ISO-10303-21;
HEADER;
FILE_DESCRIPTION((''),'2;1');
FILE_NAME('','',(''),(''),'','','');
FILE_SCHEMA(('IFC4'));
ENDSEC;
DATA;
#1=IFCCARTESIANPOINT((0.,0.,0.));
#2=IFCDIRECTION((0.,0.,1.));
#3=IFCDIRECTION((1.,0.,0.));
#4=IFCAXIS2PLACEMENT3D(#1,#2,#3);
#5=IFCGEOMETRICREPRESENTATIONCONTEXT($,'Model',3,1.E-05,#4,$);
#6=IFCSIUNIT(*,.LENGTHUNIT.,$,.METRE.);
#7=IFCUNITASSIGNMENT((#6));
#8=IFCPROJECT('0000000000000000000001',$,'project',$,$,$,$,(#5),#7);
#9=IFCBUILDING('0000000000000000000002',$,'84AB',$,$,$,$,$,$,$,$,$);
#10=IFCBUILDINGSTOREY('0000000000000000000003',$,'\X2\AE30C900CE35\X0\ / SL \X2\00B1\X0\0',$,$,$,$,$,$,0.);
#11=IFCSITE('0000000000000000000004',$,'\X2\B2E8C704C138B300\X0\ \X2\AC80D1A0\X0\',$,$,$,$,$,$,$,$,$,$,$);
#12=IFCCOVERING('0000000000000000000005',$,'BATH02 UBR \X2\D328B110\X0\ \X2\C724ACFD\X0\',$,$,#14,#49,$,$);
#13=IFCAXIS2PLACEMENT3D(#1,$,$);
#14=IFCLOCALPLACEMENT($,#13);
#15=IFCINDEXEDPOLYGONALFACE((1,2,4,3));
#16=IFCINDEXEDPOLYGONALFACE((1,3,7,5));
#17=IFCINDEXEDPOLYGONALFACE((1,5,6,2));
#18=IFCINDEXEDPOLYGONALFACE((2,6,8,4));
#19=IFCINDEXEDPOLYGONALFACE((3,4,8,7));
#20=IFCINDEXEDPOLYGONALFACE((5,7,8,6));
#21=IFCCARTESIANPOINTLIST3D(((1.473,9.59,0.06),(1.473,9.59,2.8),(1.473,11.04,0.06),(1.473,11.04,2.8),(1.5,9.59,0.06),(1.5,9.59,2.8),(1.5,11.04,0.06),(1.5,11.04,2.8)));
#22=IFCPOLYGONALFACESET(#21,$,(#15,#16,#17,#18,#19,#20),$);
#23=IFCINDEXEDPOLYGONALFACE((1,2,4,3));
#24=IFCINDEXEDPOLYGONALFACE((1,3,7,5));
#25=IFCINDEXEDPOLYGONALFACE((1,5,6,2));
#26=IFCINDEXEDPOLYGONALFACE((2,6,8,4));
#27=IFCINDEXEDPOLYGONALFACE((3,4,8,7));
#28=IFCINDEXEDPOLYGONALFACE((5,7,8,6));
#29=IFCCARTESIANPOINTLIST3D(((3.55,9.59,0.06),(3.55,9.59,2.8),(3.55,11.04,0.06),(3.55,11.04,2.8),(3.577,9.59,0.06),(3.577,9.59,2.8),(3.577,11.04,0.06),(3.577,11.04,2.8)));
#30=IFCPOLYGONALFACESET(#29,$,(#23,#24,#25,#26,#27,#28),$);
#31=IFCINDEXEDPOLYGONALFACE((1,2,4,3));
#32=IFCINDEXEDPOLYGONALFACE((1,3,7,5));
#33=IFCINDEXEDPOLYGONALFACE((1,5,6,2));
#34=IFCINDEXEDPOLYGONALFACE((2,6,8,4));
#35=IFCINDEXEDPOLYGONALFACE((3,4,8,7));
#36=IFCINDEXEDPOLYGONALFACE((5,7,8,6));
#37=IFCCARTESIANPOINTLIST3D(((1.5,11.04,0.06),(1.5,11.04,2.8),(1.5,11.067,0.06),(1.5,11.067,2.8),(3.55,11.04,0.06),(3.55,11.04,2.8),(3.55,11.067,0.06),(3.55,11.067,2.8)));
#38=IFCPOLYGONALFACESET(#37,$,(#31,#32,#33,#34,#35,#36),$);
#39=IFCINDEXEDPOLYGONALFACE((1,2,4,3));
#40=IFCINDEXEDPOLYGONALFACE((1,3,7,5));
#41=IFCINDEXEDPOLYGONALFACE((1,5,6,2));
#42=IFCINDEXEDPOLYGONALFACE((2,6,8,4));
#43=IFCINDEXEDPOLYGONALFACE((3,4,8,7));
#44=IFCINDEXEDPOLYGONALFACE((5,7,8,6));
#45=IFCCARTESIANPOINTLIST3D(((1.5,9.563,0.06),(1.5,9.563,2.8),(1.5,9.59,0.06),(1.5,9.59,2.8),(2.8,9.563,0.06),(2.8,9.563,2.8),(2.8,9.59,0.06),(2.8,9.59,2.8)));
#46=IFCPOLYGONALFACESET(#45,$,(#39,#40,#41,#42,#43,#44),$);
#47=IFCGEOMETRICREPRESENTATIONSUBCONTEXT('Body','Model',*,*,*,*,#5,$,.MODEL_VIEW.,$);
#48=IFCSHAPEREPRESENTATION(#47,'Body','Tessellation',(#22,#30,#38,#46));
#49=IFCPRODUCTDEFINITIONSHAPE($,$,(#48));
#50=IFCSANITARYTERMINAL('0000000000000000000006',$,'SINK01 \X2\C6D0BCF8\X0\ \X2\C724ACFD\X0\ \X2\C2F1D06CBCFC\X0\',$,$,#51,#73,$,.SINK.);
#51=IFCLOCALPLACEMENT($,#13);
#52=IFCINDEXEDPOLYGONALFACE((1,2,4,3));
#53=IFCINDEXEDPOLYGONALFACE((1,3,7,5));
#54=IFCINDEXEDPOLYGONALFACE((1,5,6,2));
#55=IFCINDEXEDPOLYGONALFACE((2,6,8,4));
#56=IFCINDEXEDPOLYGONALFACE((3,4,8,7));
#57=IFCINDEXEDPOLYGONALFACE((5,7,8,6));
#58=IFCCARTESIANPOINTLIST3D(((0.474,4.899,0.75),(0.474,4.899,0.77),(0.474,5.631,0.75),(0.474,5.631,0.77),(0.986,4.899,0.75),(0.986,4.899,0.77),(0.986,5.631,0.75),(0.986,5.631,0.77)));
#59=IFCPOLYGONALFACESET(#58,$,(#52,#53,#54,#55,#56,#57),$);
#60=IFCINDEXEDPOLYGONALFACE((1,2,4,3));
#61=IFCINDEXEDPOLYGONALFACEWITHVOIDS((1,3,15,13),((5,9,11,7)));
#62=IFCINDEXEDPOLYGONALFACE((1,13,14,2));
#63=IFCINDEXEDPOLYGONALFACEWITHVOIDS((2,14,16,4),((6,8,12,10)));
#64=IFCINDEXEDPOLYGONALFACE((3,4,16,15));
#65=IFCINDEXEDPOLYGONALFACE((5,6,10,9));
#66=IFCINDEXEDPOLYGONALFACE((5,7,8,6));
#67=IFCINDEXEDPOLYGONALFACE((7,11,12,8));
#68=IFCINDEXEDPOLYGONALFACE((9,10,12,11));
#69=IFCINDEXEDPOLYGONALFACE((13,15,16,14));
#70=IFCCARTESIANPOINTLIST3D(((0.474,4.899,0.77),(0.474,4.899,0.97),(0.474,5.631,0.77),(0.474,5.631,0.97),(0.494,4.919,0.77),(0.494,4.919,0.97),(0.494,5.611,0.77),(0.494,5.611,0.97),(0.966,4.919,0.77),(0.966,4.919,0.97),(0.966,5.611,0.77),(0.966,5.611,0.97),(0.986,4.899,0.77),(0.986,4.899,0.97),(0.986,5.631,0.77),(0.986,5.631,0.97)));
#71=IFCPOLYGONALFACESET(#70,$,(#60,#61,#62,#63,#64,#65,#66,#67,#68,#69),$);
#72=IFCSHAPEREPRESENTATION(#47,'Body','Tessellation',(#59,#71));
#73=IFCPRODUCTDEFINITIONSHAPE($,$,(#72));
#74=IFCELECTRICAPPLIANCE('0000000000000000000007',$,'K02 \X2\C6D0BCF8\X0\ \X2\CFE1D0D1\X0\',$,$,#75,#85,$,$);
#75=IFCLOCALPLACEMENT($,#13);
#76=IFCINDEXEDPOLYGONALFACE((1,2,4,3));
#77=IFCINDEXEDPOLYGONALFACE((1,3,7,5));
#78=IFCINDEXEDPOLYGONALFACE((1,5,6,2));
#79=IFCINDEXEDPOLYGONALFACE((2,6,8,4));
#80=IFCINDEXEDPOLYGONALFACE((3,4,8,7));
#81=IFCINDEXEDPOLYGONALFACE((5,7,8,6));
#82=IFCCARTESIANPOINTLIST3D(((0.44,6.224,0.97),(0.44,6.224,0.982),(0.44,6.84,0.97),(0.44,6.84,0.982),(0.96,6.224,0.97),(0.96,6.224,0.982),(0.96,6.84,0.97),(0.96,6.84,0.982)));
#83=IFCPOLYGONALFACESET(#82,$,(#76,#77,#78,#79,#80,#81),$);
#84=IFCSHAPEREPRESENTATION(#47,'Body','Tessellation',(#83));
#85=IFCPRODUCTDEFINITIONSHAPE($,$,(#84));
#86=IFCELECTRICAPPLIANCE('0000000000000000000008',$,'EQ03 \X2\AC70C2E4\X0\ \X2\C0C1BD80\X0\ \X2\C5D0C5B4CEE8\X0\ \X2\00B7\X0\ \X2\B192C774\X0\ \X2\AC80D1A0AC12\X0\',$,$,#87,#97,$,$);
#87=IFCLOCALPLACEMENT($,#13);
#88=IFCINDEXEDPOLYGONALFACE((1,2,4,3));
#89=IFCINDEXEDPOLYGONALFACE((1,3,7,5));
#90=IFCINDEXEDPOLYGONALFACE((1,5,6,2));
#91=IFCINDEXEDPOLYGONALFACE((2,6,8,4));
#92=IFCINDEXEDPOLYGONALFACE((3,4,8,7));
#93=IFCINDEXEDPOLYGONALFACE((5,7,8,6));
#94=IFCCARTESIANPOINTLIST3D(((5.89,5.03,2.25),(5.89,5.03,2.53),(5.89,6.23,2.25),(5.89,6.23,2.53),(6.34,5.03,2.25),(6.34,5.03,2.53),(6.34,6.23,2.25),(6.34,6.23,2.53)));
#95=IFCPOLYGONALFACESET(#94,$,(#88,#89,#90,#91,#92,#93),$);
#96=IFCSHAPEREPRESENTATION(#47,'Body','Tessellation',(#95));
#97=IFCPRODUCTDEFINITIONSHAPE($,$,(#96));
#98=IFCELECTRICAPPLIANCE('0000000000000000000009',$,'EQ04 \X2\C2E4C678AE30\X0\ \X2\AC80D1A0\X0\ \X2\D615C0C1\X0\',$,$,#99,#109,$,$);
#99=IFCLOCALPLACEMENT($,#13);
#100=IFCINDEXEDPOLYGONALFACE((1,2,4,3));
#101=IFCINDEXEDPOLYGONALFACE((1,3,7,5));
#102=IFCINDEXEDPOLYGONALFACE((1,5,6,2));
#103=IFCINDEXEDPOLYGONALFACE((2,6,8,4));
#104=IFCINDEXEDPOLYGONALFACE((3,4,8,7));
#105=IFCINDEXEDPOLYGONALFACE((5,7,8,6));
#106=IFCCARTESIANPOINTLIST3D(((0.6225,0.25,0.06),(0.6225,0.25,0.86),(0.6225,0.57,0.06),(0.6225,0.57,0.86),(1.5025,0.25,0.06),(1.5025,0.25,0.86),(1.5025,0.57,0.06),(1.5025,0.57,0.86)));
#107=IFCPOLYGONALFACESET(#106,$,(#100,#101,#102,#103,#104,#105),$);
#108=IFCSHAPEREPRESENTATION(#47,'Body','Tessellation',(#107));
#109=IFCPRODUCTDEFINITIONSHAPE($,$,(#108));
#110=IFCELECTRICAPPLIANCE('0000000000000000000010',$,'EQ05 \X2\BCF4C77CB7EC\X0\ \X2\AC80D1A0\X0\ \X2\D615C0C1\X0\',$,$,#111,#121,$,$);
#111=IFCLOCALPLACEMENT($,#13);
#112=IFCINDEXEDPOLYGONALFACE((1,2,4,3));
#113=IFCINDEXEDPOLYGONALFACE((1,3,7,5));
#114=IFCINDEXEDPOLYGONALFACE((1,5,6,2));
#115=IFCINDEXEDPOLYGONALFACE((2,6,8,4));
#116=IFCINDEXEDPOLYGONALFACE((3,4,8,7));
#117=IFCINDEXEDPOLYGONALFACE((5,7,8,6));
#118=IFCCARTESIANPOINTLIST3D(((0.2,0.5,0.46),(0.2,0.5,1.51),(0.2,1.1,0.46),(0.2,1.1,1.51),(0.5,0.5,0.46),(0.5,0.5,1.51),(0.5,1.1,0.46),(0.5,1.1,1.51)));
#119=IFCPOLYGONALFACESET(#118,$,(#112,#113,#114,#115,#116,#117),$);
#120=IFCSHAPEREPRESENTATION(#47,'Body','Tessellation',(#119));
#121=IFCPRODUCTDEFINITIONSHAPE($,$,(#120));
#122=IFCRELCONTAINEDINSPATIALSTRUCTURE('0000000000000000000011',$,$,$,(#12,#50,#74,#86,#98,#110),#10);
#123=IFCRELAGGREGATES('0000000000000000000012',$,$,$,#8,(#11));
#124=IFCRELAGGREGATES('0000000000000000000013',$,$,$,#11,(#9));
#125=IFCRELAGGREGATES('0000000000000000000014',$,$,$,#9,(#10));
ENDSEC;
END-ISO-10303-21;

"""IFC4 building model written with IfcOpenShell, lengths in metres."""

from ifc_helpers import new_model, si_unit, frame, origin_with_axes, place, context, subcontext, project, spatial, polyline, outline, extrude, element, save


model = new_model("IFC4")

# Units and contexts
model_context = context("Model", 3, precision=1e-05, world=origin_with_axes())
body_context = subcontext(model_context, "Body", "Model", "MODEL_VIEW")
ifc_project = project(units=[si_unit("LENGTHUNIT", "METRE")], contexts=[model_context])

# Site, building, storey
site = spatial("IfcSite", under=ifc_project, Name="단위세대 검토")
building = spatial("IfcBuilding", under=site, Name="84AB")
storey = spatial("IfcBuildingStorey", under=building, Name="기준층 / SL ±0", Elevation=0.0)

# Covering
covering_placement = place(None, origin_with_axes())
element("IfcCovering", 1, at=covering_placement, inside=storey, Name="BATH02 UBR 패널 윤곽", context=body_context, shape_type="SweptSolid", body=[
    extrude(outline(polyline([(1.5, 9.59), (1.5, 11.04), (1.473, 11.04), (1.473, 9.59), (1.5, 9.59)])), frame((0.0, 0.0, 0.06)), (0.0, 0.0, 1.0), 2.74),
    extrude(outline(polyline([(3.577, 9.59), (3.577, 11.04), (3.55, 11.04), (3.55, 9.59), (3.577, 9.59)])), frame((0.0, 0.0, 0.06)), (0.0, 0.0, 1.0), 2.74),
    extrude(outline(polyline([(3.55, 11.04), (3.55, 11.067), (1.5, 11.067), (1.5, 11.04), (3.55, 11.04)])), frame((0.0, 0.0, 0.06)), (0.0, 0.0, 1.0), 2.74),
    extrude(outline(polyline([(2.8, 9.563), (2.8, 9.59), (1.5, 9.59), (1.5, 9.563), (2.8, 9.563)])), frame((0.0, 0.0, 0.06)), (0.0, 0.0, 1.0), 2.74),
])

# Sanitary terminal
sanitary_terminal_1_placement = place(None, origin_with_axes())
element("IfcSanitaryTerminal", 2, at=sanitary_terminal_1_placement, inside=storey, Name="SINK01 원본 윤곽 싱크볼", PredefinedType="SINK", context=body_context, shape_type="SweptSolid", body=[
    extrude(outline(polyline([(0.986, 4.899), (0.986, 5.631), (0.474, 5.631), (0.474, 4.899), (0.986, 4.899)])), frame((0.0, 0.0, 0.75)), (0.0, 0.0, 1.0), 0.02),
    extrude(outline(polyline([(0.474, 4.899), (0.474, 5.631), (0.986, 5.631), (0.986, 4.899), (0.474, 4.899)]), holes=[polyline([(0.966, 5.611), (0.494, 5.611), (0.494, 4.919), (0.966, 4.919), (0.966, 5.611)])]), frame((0.0, 0.0, 0.77)), (0.0, 0.0, 1.0), 0.2),
])

# Electric appliance
electric_appliance_1_placement = place(None, origin_with_axes())
element("IfcElectricAppliance", 3, at=electric_appliance_1_placement, inside=storey, Name="K02 원본 쿡탑", context=body_context, shape_type="SweptSolid", body=[
    extrude(outline(polyline([(0.96, 6.224), (0.96, 6.84), (0.44, 6.84), (0.44, 6.224), (0.96, 6.224)])), frame((0.0, 0.0, 0.97)), (0.0, 0.0, 1.0), 0.012),
])

# Electric appliances
electric_appliance_2_placement = place(None, origin_with_axes())
element("IfcElectricAppliance", 4, at=electric_appliance_2_placement, inside=storey, Name="EQ03 거실 상부 에어컨 · 높이 검토값", context=body_context, shape_type="SweptSolid", body=[
    extrude(outline(polyline([(5.89, 6.23), (5.89, 5.03), (6.34, 5.03), (6.34, 6.23), (5.89, 6.23)])), frame((0.0, 0.0, 2.25)), (0.0, 0.0, 1.0), 0.28),
])
electric_appliance_3_placement = place(None, origin_with_axes())
element("IfcElectricAppliance", 5, at=electric_appliance_3_placement, inside=storey, Name="EQ04 실외기 검토 형상", context=body_context, shape_type="SweptSolid", body=[
    extrude(outline(polyline([(1.5025, 0.25), (0.6225, 0.25), (0.6225, 0.57), (1.5025, 0.57), (1.5025, 0.25)])), frame((0.0, 0.0, 0.06)), (0.0, 0.0, 1.0), 0.8),
])
electric_appliance_4_placement = place(None, origin_with_axes())
element("IfcElectricAppliance", 6, at=electric_appliance_4_placement, inside=storey, Name="EQ05 보일러 검토 형상", context=body_context, shape_type="SweptSolid", body=[
    extrude(outline(polyline([(0.5, 0.5), (0.2, 0.5), (0.2, 1.1), (0.5, 1.1), (0.5, 0.5)])), frame((0.0, 0.0, 0.46)), (0.0, 0.0, 1.0), 1.05),
])

save(model, "model.ifc")
